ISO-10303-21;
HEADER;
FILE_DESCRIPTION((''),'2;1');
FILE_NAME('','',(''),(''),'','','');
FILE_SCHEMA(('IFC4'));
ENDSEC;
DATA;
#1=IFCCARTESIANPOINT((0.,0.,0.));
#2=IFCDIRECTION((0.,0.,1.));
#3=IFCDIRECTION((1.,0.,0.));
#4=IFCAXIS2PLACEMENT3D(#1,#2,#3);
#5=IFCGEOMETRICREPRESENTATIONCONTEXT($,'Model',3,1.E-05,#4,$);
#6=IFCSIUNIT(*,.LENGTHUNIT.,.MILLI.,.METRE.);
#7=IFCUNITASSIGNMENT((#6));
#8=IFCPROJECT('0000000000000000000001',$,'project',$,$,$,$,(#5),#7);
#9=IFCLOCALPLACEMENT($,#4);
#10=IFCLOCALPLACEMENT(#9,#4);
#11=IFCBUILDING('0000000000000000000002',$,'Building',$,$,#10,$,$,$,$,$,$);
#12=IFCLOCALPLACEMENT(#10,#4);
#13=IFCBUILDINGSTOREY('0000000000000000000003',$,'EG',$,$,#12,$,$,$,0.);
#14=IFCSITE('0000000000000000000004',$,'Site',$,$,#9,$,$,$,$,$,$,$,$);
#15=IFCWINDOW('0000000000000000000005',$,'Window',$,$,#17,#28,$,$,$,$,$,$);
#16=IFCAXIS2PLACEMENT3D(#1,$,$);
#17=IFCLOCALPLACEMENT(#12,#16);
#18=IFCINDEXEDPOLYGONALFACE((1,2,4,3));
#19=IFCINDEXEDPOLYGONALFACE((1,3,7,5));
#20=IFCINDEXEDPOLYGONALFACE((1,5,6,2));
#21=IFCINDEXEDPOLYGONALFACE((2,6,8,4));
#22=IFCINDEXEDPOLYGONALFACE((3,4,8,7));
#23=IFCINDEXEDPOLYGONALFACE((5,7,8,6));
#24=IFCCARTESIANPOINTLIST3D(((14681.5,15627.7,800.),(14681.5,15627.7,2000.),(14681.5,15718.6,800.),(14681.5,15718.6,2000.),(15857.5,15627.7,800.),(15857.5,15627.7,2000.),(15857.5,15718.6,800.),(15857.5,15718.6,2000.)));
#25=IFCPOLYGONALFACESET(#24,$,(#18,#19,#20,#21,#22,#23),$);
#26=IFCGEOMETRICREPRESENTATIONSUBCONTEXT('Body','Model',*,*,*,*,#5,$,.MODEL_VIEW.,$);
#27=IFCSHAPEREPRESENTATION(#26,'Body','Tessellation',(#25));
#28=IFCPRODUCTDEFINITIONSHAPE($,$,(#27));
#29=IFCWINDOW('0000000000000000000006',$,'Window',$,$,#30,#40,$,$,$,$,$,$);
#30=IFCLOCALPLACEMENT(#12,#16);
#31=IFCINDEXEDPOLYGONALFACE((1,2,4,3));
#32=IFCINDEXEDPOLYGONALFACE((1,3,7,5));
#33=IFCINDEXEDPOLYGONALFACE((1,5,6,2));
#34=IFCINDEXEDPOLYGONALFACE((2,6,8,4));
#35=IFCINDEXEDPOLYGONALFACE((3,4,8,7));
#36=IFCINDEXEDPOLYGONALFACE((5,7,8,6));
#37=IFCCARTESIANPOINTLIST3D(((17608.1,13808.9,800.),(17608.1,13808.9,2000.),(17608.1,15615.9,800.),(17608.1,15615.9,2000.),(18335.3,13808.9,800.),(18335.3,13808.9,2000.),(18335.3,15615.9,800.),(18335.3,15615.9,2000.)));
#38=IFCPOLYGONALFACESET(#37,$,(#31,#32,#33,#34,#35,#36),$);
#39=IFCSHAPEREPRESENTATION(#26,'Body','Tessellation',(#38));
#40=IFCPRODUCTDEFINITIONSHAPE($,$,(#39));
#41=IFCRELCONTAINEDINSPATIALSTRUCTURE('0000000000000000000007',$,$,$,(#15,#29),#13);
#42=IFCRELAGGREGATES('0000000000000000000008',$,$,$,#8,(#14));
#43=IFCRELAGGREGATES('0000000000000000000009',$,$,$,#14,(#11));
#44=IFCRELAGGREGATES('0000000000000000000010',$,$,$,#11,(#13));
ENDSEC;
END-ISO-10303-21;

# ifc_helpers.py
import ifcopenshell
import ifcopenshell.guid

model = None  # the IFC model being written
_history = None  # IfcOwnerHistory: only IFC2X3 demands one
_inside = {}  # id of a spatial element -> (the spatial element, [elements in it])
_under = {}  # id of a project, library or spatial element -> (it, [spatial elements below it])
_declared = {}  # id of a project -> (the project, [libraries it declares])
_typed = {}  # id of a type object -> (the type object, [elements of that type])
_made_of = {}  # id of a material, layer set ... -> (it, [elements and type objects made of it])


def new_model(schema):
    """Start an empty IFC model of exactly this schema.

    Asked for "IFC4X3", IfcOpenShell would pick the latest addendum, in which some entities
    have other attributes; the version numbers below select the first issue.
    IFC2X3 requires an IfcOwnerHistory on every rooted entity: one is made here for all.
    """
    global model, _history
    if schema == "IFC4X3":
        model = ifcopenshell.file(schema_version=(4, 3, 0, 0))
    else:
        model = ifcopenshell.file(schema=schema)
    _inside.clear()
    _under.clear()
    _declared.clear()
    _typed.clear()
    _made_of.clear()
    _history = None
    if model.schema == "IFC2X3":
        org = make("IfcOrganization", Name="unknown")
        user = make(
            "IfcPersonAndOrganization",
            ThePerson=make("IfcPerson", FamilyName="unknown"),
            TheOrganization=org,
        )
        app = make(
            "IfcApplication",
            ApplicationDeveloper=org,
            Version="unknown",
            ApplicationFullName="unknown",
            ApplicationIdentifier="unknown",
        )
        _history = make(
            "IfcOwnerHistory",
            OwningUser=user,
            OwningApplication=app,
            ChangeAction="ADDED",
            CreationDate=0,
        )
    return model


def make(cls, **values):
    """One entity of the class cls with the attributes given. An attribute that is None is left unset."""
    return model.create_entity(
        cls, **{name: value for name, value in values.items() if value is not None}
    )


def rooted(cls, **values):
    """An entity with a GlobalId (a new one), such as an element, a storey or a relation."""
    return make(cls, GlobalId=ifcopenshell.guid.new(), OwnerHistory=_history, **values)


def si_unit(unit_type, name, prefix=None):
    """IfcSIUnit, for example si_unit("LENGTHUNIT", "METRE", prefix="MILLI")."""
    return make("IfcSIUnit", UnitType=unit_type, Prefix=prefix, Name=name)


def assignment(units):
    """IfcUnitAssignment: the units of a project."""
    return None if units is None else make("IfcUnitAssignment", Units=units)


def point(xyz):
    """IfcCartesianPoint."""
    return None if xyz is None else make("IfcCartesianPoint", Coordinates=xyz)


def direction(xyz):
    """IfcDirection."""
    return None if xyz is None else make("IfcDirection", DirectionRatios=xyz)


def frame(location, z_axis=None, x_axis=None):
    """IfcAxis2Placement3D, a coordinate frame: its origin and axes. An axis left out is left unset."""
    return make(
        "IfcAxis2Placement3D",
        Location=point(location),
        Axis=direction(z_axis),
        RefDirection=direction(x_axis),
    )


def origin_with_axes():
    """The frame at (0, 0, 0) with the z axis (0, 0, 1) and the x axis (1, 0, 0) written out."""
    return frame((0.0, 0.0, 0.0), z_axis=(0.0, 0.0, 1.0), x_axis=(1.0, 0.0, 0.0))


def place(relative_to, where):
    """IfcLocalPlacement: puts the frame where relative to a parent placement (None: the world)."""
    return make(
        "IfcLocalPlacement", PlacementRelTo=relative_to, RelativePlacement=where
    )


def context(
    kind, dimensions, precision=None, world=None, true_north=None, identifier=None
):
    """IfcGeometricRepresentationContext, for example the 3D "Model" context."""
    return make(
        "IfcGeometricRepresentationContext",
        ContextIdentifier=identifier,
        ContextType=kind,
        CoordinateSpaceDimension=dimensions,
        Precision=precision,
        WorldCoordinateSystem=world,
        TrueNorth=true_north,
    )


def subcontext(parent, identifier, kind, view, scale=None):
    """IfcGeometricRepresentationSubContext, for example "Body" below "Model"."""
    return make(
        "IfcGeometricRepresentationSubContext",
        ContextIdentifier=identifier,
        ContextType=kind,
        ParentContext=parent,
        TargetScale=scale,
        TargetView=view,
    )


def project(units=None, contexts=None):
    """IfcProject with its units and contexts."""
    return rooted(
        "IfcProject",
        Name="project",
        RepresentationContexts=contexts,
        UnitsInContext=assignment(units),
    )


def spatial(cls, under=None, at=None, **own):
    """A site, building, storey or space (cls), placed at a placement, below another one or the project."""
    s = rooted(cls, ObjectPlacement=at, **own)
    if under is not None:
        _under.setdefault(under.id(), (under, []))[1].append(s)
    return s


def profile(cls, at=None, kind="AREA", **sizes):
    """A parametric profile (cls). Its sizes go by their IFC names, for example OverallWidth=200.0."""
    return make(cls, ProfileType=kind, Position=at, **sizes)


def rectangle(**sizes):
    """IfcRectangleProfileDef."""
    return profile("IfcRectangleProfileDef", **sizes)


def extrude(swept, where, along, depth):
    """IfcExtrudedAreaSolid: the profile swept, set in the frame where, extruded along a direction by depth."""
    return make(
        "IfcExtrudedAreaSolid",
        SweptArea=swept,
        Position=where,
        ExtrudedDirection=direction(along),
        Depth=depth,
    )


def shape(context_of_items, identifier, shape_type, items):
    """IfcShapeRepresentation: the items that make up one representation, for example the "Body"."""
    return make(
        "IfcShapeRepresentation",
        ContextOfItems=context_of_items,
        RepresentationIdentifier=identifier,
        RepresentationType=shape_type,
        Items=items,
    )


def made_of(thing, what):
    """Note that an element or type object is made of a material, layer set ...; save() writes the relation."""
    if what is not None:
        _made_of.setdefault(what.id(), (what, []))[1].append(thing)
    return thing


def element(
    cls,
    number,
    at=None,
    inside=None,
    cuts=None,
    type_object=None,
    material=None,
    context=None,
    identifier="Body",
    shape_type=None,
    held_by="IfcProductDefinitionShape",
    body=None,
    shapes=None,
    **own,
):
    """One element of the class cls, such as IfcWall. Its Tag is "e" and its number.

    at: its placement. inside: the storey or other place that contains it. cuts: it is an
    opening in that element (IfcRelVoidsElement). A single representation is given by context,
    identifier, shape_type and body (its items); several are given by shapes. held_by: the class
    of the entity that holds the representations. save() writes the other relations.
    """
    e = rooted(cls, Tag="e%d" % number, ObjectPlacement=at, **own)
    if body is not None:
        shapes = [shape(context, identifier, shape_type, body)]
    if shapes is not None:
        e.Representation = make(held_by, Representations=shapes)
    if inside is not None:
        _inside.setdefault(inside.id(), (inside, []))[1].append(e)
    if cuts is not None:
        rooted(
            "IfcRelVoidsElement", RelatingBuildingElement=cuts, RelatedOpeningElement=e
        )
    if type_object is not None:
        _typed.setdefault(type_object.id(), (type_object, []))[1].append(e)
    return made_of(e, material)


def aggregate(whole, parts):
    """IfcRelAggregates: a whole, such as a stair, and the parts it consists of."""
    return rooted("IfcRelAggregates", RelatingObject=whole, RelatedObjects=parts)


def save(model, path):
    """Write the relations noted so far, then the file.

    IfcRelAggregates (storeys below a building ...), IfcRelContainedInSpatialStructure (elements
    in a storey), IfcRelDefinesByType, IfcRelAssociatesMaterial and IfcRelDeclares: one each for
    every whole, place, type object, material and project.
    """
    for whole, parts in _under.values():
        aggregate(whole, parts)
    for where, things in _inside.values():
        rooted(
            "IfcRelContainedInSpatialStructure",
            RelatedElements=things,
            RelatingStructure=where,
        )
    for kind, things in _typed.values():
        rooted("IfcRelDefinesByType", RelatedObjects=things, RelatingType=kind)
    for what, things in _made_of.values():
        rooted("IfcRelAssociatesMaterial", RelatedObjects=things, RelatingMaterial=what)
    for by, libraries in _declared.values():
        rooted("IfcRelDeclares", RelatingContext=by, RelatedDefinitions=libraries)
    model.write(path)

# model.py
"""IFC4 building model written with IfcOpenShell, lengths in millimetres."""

from ifc_helpers import new_model, si_unit, frame, origin_with_axes, place, context, subcontext, project, spatial, rectangle, extrude, element, save


model = new_model("IFC4")

# Units and contexts
model_context = context("Model", 3, precision=1e-05, world=origin_with_axes())
body_context = subcontext(model_context, "Body", "Model", "MODEL_VIEW")
ifc_project = project(units=[si_unit("LENGTHUNIT", "METRE", prefix="MILLI")], contexts=[model_context])

# Site, building, storey
site_placement = place(None, origin_with_axes())
site = spatial("IfcSite", under=ifc_project, at=site_placement, Name="Site")
building_placement = place(site_placement, origin_with_axes())
building = spatial("IfcBuilding", under=site, at=building_placement, Name="Building")
storey_placement = place(building_placement, origin_with_axes())
storey = spatial("IfcBuildingStorey", under=building, at=storey_placement, Name="EG", Elevation=0.0)

# Windows
window_1_placement = place(storey_placement, origin_with_axes())
element("IfcWindow", 1, at=window_1_placement, inside=storey, Name="Window", context=body_context, shape_type="SweptSolid", body=[
    extrude(rectangle(XDim=1176.0, YDim=90.9), frame((15269.5, 15673.2, 800.0), z_axis=(0.0, 0.0, 1.0), x_axis=(1.0, 0.0, 0.0)), (0.0, 0.0, 1.0), 1200.0),
])
window_2_placement = place(storey_placement, origin_with_axes())
element("IfcWindow", 2, at=window_2_placement, inside=storey, Name="Window", context=body_context, shape_type="SweptSolid", body=[
    extrude(rectangle(XDim=1807.0, YDim=727.2), frame((17971.7, 14712.4, 800.0), z_axis=(0.0, 0.0, 1.0), x_axis=(0.0, 1.0, 0.0)), (0.0, 0.0, 1.0), 1200.0),
])

save(model, "model.ifc")
